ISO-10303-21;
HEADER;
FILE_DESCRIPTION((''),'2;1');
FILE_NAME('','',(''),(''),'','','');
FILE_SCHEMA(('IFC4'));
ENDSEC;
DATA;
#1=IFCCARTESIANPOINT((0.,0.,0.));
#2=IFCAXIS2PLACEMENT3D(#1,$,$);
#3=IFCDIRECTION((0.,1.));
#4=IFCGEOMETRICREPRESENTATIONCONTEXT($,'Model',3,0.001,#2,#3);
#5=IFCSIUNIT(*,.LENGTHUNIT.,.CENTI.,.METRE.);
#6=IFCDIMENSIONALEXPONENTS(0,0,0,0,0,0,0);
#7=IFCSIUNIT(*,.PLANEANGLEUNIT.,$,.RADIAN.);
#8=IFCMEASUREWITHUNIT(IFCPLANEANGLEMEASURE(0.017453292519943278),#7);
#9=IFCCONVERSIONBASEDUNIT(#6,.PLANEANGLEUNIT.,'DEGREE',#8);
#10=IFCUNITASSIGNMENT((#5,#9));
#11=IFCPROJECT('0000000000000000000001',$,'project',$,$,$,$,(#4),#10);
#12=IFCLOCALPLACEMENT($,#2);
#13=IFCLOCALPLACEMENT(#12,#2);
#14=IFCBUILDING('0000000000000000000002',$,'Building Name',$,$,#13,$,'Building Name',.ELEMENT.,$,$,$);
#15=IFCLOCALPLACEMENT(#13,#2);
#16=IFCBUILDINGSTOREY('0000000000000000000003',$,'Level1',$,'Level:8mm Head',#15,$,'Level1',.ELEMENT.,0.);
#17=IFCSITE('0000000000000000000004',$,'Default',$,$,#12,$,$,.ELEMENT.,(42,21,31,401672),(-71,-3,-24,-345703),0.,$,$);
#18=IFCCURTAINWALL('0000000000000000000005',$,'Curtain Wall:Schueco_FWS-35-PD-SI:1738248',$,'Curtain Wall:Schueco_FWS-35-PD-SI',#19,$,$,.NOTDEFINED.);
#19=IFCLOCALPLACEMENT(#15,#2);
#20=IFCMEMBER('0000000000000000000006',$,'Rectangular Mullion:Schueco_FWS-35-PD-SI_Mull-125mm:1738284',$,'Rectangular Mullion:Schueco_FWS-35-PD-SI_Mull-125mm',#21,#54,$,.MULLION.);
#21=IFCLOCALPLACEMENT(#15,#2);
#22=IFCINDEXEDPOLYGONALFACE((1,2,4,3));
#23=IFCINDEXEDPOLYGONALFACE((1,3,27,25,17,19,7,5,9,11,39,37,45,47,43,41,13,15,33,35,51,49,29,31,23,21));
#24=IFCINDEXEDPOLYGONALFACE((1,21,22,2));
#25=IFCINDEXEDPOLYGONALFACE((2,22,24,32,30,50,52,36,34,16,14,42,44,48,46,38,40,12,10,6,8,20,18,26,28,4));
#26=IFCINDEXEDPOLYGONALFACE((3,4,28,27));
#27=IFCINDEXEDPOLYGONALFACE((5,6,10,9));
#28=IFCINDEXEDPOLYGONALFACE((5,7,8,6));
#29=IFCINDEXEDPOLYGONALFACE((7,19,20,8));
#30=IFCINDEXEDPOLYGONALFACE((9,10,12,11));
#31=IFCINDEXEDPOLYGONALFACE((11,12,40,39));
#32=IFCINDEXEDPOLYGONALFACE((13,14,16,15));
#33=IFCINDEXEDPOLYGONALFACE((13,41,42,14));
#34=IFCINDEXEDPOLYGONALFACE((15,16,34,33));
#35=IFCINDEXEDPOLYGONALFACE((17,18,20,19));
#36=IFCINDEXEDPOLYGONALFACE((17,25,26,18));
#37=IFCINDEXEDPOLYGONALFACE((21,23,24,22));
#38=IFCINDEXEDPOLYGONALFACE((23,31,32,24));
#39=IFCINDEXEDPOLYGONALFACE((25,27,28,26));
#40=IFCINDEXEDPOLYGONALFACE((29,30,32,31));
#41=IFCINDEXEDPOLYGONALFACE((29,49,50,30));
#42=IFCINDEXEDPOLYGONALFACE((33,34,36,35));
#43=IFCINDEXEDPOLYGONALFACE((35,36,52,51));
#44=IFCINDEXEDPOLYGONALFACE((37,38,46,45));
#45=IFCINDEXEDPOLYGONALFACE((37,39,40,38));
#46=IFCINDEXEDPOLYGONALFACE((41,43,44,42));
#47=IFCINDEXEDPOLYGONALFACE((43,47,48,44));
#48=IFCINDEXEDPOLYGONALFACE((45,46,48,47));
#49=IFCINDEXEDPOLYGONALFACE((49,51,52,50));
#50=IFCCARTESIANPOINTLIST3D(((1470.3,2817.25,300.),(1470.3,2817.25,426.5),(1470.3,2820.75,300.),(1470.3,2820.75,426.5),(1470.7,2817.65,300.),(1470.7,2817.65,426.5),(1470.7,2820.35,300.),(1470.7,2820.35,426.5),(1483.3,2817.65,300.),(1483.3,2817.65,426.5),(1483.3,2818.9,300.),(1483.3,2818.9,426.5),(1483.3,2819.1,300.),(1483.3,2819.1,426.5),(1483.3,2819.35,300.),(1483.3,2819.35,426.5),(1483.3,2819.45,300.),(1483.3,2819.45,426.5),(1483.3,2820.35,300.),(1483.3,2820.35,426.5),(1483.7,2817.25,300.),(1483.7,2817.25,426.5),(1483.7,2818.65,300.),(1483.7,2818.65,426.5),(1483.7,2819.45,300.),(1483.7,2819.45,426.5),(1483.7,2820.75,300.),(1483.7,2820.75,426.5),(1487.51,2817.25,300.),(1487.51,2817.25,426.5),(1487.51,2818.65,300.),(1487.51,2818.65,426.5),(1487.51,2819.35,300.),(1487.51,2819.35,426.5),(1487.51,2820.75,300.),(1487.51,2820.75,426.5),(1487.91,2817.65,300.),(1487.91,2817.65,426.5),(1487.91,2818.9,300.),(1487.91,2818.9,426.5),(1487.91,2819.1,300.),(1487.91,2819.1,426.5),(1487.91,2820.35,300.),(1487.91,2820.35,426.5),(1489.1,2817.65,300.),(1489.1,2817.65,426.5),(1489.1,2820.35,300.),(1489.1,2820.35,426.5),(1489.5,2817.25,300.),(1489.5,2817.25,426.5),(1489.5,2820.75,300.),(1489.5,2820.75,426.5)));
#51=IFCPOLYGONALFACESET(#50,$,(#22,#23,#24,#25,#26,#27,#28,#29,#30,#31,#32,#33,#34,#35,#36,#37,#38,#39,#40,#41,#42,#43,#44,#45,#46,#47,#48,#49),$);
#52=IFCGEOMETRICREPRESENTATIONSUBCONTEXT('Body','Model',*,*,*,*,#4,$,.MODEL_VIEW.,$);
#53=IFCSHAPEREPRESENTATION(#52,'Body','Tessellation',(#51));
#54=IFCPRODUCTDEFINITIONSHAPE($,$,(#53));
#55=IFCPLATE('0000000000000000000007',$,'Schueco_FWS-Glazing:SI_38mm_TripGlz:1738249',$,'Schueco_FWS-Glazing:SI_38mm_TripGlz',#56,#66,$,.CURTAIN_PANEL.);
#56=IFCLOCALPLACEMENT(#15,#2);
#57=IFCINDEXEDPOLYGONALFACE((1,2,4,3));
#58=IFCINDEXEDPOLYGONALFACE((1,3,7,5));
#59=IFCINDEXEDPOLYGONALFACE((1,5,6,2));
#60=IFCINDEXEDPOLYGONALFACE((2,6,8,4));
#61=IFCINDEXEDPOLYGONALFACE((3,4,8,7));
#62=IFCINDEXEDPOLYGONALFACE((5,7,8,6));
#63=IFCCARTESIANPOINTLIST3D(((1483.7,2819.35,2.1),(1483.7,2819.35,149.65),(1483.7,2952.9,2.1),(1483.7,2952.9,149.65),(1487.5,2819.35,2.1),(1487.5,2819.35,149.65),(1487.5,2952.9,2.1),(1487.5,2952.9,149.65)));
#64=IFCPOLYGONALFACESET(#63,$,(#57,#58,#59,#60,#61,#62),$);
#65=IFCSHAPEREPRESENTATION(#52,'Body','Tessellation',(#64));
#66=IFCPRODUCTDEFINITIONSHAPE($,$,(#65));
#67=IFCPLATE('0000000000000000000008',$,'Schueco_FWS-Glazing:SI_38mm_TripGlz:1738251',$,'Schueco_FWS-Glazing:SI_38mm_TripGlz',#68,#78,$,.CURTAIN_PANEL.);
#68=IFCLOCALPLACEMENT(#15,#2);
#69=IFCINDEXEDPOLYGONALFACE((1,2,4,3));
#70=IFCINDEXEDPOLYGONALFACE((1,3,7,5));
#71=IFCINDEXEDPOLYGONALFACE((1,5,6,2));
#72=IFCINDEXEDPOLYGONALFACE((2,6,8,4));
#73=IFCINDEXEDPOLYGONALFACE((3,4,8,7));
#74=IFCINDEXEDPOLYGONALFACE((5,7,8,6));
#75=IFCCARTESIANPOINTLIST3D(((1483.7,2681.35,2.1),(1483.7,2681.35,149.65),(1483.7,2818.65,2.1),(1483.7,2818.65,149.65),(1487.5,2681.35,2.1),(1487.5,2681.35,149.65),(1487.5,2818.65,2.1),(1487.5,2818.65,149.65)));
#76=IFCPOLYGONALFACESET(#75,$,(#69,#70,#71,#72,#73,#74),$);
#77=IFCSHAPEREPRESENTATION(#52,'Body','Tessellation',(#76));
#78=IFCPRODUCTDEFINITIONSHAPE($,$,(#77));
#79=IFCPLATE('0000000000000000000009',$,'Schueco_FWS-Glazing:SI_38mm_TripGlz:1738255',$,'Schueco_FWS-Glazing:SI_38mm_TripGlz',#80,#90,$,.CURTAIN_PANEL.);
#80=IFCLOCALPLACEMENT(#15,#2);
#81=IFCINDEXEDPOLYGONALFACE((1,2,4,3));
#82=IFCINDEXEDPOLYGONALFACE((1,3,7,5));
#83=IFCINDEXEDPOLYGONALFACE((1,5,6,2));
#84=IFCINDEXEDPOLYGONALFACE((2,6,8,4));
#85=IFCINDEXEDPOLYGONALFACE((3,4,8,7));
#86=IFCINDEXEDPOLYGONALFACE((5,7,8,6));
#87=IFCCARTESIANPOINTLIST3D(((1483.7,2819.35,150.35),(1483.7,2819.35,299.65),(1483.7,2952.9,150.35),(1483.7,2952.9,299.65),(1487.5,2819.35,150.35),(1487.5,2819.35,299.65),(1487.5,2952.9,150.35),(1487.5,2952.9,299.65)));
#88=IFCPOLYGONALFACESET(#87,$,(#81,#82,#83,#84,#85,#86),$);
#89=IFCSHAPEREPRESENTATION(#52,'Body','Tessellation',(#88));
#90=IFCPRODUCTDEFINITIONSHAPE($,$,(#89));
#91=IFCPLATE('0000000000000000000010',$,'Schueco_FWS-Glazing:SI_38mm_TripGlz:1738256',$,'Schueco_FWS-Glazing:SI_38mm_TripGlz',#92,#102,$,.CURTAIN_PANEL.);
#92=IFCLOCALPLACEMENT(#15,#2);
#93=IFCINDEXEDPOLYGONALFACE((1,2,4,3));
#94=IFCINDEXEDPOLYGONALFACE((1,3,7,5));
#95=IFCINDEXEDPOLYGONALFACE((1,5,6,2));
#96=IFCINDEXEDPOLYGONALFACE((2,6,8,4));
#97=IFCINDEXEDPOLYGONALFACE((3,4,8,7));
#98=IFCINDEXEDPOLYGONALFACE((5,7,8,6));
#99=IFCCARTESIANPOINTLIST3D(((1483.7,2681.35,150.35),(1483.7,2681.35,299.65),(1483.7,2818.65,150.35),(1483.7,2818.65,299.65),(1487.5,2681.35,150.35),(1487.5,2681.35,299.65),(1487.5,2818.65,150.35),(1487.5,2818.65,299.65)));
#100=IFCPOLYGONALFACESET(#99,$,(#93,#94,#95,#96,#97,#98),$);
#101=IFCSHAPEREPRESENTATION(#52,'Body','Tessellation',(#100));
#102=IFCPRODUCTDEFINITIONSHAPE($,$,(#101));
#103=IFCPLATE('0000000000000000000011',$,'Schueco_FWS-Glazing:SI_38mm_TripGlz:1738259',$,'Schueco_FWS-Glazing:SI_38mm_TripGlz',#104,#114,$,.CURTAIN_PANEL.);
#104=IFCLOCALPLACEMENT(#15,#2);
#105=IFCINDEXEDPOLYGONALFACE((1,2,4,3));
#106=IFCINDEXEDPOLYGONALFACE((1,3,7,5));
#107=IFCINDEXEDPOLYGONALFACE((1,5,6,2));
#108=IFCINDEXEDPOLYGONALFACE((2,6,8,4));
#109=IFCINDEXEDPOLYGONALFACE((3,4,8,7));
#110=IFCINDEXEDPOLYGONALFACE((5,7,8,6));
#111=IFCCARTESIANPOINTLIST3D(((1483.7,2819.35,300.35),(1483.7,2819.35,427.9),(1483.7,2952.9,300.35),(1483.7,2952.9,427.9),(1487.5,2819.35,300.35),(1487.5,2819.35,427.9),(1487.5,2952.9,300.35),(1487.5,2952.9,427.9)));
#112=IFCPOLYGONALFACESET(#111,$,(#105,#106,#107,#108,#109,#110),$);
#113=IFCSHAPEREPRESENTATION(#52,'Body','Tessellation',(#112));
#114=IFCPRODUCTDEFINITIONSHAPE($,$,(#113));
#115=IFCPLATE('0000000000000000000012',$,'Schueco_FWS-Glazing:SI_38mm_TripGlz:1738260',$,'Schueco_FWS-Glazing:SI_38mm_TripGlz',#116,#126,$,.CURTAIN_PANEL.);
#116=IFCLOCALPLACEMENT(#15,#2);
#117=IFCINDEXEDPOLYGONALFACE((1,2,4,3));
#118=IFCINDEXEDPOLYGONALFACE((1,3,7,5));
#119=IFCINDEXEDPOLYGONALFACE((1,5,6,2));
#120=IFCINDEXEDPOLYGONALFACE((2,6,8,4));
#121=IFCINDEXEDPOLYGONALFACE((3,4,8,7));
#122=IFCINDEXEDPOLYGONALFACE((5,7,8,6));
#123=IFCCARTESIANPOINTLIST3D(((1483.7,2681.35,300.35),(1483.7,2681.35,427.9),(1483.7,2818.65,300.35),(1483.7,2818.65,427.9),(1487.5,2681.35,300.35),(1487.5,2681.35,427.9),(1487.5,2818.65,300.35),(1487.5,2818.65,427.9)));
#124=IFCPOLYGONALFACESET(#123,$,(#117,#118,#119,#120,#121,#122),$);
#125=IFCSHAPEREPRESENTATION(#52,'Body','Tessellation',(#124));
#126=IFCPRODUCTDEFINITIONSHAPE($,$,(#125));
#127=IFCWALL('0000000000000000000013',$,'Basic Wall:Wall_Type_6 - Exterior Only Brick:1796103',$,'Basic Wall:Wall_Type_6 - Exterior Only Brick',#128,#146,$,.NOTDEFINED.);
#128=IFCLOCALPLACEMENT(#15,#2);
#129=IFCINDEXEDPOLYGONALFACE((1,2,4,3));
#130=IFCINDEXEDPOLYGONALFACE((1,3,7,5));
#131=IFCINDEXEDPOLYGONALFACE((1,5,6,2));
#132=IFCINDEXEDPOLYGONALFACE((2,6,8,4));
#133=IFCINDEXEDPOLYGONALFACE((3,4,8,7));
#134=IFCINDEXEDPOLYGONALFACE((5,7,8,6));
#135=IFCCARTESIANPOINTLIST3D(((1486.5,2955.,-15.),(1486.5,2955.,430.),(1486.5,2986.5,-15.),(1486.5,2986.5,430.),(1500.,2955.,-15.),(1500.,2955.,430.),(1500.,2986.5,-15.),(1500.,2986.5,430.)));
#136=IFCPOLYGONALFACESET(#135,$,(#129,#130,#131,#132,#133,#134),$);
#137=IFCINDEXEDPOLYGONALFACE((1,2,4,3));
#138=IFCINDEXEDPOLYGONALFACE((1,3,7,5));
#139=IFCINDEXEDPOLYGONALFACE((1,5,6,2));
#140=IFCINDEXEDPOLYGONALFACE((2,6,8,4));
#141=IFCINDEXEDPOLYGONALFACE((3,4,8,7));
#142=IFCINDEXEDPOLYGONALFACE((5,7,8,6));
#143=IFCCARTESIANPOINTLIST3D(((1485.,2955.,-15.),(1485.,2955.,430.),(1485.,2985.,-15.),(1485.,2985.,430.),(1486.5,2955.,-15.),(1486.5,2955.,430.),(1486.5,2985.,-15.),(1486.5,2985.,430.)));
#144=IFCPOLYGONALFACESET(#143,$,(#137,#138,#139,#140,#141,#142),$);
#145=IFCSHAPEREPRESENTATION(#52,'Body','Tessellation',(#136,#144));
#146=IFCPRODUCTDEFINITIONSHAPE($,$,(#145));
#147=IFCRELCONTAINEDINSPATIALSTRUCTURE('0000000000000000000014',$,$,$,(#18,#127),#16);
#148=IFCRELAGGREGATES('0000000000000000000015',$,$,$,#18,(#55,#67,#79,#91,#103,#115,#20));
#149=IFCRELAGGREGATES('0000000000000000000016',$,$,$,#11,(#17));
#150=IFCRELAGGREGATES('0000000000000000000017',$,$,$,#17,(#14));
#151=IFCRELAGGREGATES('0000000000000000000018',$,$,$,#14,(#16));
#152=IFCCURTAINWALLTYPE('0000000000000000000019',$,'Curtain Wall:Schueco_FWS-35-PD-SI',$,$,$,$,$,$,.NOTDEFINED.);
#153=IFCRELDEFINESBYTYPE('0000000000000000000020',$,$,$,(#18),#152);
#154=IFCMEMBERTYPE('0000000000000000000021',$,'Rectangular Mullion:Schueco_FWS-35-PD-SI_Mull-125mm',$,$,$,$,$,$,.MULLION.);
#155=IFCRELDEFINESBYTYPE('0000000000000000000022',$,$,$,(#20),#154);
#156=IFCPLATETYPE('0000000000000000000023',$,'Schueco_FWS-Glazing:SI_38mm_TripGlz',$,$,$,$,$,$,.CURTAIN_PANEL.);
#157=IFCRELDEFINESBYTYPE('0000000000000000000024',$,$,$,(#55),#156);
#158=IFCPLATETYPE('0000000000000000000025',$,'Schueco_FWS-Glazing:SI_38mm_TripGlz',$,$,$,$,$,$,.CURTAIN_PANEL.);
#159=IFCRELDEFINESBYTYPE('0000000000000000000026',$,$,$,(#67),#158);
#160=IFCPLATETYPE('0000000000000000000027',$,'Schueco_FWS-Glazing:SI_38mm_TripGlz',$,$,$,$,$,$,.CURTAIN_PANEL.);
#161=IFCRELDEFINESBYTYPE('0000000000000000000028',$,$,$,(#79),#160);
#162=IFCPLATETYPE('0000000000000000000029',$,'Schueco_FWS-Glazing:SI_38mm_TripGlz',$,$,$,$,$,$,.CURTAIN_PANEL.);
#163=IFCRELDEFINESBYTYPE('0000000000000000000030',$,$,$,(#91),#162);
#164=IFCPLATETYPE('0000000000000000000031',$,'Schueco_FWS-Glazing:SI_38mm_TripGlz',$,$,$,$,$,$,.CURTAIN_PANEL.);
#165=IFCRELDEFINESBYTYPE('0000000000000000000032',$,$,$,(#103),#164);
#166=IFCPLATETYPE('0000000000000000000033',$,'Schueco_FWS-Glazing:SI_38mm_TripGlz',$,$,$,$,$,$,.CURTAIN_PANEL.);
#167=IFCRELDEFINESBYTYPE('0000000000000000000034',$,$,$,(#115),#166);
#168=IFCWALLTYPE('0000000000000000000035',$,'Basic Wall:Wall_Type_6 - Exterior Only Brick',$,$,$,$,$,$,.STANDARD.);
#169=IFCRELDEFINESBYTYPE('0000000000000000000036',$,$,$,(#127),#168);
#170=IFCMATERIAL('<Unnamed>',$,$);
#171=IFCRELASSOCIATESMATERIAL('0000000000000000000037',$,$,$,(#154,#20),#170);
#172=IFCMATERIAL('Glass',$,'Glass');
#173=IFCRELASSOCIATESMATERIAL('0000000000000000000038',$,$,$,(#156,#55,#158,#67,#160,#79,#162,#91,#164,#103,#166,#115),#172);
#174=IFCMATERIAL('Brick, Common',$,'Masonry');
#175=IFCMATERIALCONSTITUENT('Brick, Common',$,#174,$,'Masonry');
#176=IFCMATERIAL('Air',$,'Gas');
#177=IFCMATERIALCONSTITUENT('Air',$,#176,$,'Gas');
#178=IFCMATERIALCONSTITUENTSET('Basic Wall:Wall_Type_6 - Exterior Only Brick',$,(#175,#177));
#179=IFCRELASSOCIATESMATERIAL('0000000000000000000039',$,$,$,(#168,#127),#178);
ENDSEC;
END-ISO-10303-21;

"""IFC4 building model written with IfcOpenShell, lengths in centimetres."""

from ifc_helpers import new_model, entity, si_unit, converted_unit, direction, frame, origin, place, context, subcontext, project, spatial, indexed_curve, outline, extrude, source, transform, mapped, material, constituent, constituent_set, type_object, type_shapes, element, aggregate, save


model = new_model("IFC4")

# Units and contexts
model_context = context("Model", 3, precision=0.001, world=origin(), true_north=direction((0.0, 1.0)))
body_context = subcontext(model_context, "Body", "Model", "MODEL_VIEW")
ifc_project = project(units=[si_unit("LENGTHUNIT", "METRE", prefix="CENTI"), converted_unit("PLANEANGLEUNIT", "DEGREE", entity("IfcPlaneAngleMeasure", 0.017453292519943278), si_unit("PLANEANGLEUNIT", "RADIAN"), dimensions=[0, 0, 0, 0, 0, 0, 0])], contexts=[model_context])

# Site, building, storey
site_placement = place(None, origin())
site = spatial("IfcSite", under=ifc_project, at=site_placement, Name="Default", CompositionType="ELEMENT", RefLatitude=(42, 21, 31, 401672), RefLongitude=(-71, -3, -24, -345703), RefElevation=0.0)
building_placement = place(site_placement, origin())
building = spatial("IfcBuilding", under=site, at=building_placement, Name="Building Name", LongName="Building Name", CompositionType="ELEMENT")
storey_placement = place(building_placement, origin())
storey = spatial("IfcBuildingStorey", under=building, at=storey_placement, Name="Level1", ObjectType="Level:8mm Head", LongName="Level1", CompositionType="ELEMENT", Elevation=0.0)

# Curtain wall, member, plates
curtain_wall_type = type_object("IfcCurtainWallType", Name="Curtain Wall:Schueco_FWS-35-PD-SI", PredefinedType="NOTDEFINED")
curtain_wall_placement = place(storey_placement, origin())
curtain_wall = element("IfcCurtainWall", 1, at=curtain_wall_placement, inside=storey, type_object=curtain_wall_type, Name="Curtain Wall:Schueco_FWS-35-PD-SI:1738248", ObjectType="Curtain Wall:Schueco_FWS-35-PD-SI", PredefinedType="NOTDEFINED")
ifc_material_1 = material(Name="<Unnamed>")
member_type_1 = type_object("IfcMemberType", Name="Rectangular Mullion:Schueco_FWS-35-PD-SI_Mull-125mm", PredefinedType="MULLION", material=ifc_material_1)
shared_shape_1 = source(origin(), body_context, "Body", "SweptSolid", [
    extrude(outline(indexed_curve([(-1.78, -13.37), (1.72, -13.37), (1.72, 0.03), (0.42, 0.03), (0.42, -0.37), (1.32, -0.37), (1.32, -12.97), (-1.38, -12.97), (-1.38, -0.37), (-0.13, -0.37), (-0.13, 4.24), (-1.38, 4.24), (-1.38, 5.43), (1.32, 5.43), (1.32, 4.24), (0.07, 4.24), (0.07, -0.37), (0.32, -0.37), (0.32, 3.84), (1.72, 3.84), (1.72, 5.83), (-1.78, 5.83), (-1.78, 3.84), (-0.38, 3.84), (-0.38, 0.03), (-1.78, 0.03), (-1.78, -13.37)], self_intersect=False)), frame((-0.03, 3.83, -126.5), z_axis=(0.0, 0.0, 1.0), x_axis=(-1.0, 0.0, 0.0)), (0.0, 0.0, 1.0), 126.5),
])
type_shapes(member_type_1, [shared_shape_1])
member_1_placement = place(curtain_wall_placement, frame((1487.5, 2819.0, 300.0), z_axis=(0.0, 0.0, -1.0), x_axis=(0.0, -1.0, 0.0)))
member_1 = element("IfcMember", 2, at=member_1_placement, type_object=member_type_1, material=ifc_material_1, Name="Rectangular Mullion:Schueco_FWS-35-PD-SI_Mull-125mm:1738284", ObjectType="Rectangular Mullion:Schueco_FWS-35-PD-SI_Mull-125mm", PredefinedType="MULLION", context=body_context, shape_type="MappedRepresentation", body=[
    mapped(shared_shape_1, transform((0.0, 0.0, 0.0), scale=1.0)),
])
ifc_material_2 = material(Name="Glass", Category="Glass")
plate_type_1 = type_object("IfcPlateType", Name="Schueco_FWS-Glazing:SI_38mm_TripGlz", PredefinedType="CURTAIN_PANEL", material=ifc_material_2)
shared_shape_2 = source(origin(), body_context, "Body", "SweptSolid", [
    extrude(outline(indexed_curve([(-1.9, -66.78), (1.9, -66.78), (1.9, 66.78), (-1.9, 66.78), (-1.9, -66.78)], self_intersect=False)), frame((0.0, -1.9, 0.0), z_axis=(0.0, 0.0, 1.0), x_axis=(0.0, 1.0, 0.0)), (0.0, 0.0, 1.0), 147.55),
])
type_shapes(plate_type_1, [shared_shape_2])
plate_1_placement = place(curtain_wall_placement, frame((1487.5, 2886.12, 2.1), z_axis=(0.0, 0.0, 1.0), x_axis=(0.0, -1.0, 0.0)))
plate_1 = element("IfcPlate", 3, at=plate_1_placement, type_object=plate_type_1, material=ifc_material_2, Name="Schueco_FWS-Glazing:SI_38mm_TripGlz:1738249", ObjectType="Schueco_FWS-Glazing:SI_38mm_TripGlz", PredefinedType="CURTAIN_PANEL", context=body_context, shape_type="MappedRepresentation", body=[
    mapped(shared_shape_2, transform((0.0, 0.0, 0.0), scale=1.0)),
])
plate_type_2 = type_object("IfcPlateType", Name="Schueco_FWS-Glazing:SI_38mm_TripGlz", PredefinedType="CURTAIN_PANEL", material=ifc_material_2)
shared_shape_3 = source(origin(), body_context, "Body", "SweptSolid", [
    extrude(outline(indexed_curve([(-1.9, -68.65), (1.9, -68.65), (1.9, 68.65), (-1.9, 68.65), (-1.9, -68.65)], self_intersect=False)), frame((0.0, -1.9, 0.0), z_axis=(0.0, 0.0, 1.0), x_axis=(0.0, 1.0, 0.0)), (0.0, 0.0, 1.0), 147.55),
])
type_shapes(plate_type_2, [shared_shape_3])
plate_2_placement = place(curtain_wall_placement, frame((1487.5, 2750.0, 2.1), z_axis=(0.0, 0.0, 1.0), x_axis=(0.0, -1.0, 0.0)))
plate_2 = element("IfcPlate", 4, at=plate_2_placement, type_object=plate_type_2, material=ifc_material_2, Name="Schueco_FWS-Glazing:SI_38mm_TripGlz:1738251", ObjectType="Schueco_FWS-Glazing:SI_38mm_TripGlz", PredefinedType="CURTAIN_PANEL", context=body_context, shape_type="MappedRepresentation", body=[
    mapped(shared_shape_3, transform((0.0, 0.0, 0.0), scale=1.0)),
])
plate_type_3 = type_object("IfcPlateType", Name="Schueco_FWS-Glazing:SI_38mm_TripGlz", PredefinedType="CURTAIN_PANEL", material=ifc_material_2)
shared_shape_4 = source(origin(), body_context, "Body", "SweptSolid", [
    extrude(outline(indexed_curve([(-1.9, -66.78), (1.9, -66.78), (1.9, 66.78), (-1.9, 66.78), (-1.9, -66.78)], self_intersect=False)), frame((0.0, -1.9, 0.0), z_axis=(0.0, 0.0, 1.0), x_axis=(0.0, 1.0, 0.0)), (0.0, 0.0, 1.0), 149.3),
])
type_shapes(plate_type_3, [shared_shape_4])
plate_3_placement = place(curtain_wall_placement, frame((1487.5, 2886.12, 150.35), z_axis=(0.0, 0.0, 1.0), x_axis=(0.0, -1.0, 0.0)))
plate_3 = element("IfcPlate", 5, at=plate_3_placement, type_object=plate_type_3, material=ifc_material_2, Name="Schueco_FWS-Glazing:SI_38mm_TripGlz:1738255", ObjectType="Schueco_FWS-Glazing:SI_38mm_TripGlz", PredefinedType="CURTAIN_PANEL", context=body_context, shape_type="MappedRepresentation", body=[
    mapped(shared_shape_4, transform((0.0, 0.0, 0.0), scale=1.0)),
])
plate_type_4 = type_object("IfcPlateType", Name="Schueco_FWS-Glazing:SI_38mm_TripGlz", PredefinedType="CURTAIN_PANEL", material=ifc_material_2)
shared_shape_5 = source(origin(), body_context, "Body", "SweptSolid", [
    extrude(outline(indexed_curve([(-1.9, -68.65), (1.9, -68.65), (1.9, 68.65), (-1.9, 68.65), (-1.9, -68.65)], self_intersect=False)), frame((0.0, -1.9, 0.0), z_axis=(0.0, 0.0, 1.0), x_axis=(0.0, 1.0, 0.0)), (0.0, 0.0, 1.0), 149.3),
])
type_shapes(plate_type_4, [shared_shape_5])
plate_4_placement = place(curtain_wall_placement, frame((1487.5, 2750.0, 150.35), z_axis=(0.0, 0.0, 1.0), x_axis=(0.0, -1.0, 0.0)))
plate_4 = element("IfcPlate", 6, at=plate_4_placement, type_object=plate_type_4, material=ifc_material_2, Name="Schueco_FWS-Glazing:SI_38mm_TripGlz:1738256", ObjectType="Schueco_FWS-Glazing:SI_38mm_TripGlz", PredefinedType="CURTAIN_PANEL", context=body_context, shape_type="MappedRepresentation", body=[
    mapped(shared_shape_5, transform((0.0, 0.0, 0.0), scale=1.0)),
])
plate_type_5 = type_object("IfcPlateType", Name="Schueco_FWS-Glazing:SI_38mm_TripGlz", PredefinedType="CURTAIN_PANEL", material=ifc_material_2)
shared_shape_6 = source(origin(), body_context, "Body", "SweptSolid", [
    extrude(outline(indexed_curve([(-1.9, -66.77), (1.9, -66.77), (1.9, 66.77), (-1.9, 66.77), (-1.9, -66.77)], self_intersect=False)), frame((0.0, -1.9, 0.0), z_axis=(0.0, 0.0, 1.0), x_axis=(0.0, 1.0, 0.0)), (0.0, 0.0, 1.0), 127.55),
])
type_shapes(plate_type_5, [shared_shape_6])
plate_5_placement = place(curtain_wall_placement, frame((1487.5, 2886.12, 300.35), z_axis=(0.0, 0.0, 1.0), x_axis=(0.0, -1.0, 0.0)))
plate_5 = element("IfcPlate", 7, at=plate_5_placement, type_object=plate_type_5, material=ifc_material_2, Name="Schueco_FWS-Glazing:SI_38mm_TripGlz:1738259", ObjectType="Schueco_FWS-Glazing:SI_38mm_TripGlz", PredefinedType="CURTAIN_PANEL", context=body_context, shape_type="MappedRepresentation", body=[
    mapped(shared_shape_6, transform((0.0, 0.0, 0.0), scale=1.0)),
])
plate_type_6 = type_object("IfcPlateType", Name="Schueco_FWS-Glazing:SI_38mm_TripGlz", PredefinedType="CURTAIN_PANEL", material=ifc_material_2)
shared_shape_7 = source(origin(), body_context, "Body", "SweptSolid", [
    extrude(outline(indexed_curve([(-1.9, -68.65), (1.9, -68.65), (1.9, 68.65), (-1.9, 68.65), (-1.9, -68.65)], self_intersect=False)), frame((0.0, -1.9, 0.0), z_axis=(0.0, 0.0, 1.0), x_axis=(0.0, 1.0, 0.0)), (0.0, 0.0, 1.0), 127.55),
])
type_shapes(plate_type_6, [shared_shape_7])
plate_6_placement = place(curtain_wall_placement, frame((1487.5, 2750.0, 300.35), z_axis=(0.0, 0.0, 1.0), x_axis=(0.0, -1.0, 0.0)))
plate_6 = element("IfcPlate", 8, at=plate_6_placement, type_object=plate_type_6, material=ifc_material_2, Name="Schueco_FWS-Glazing:SI_38mm_TripGlz:1738260", ObjectType="Schueco_FWS-Glazing:SI_38mm_TripGlz", PredefinedType="CURTAIN_PANEL", context=body_context, shape_type="MappedRepresentation", body=[
    mapped(shared_shape_7, transform((0.0, 0.0, 0.0), scale=1.0)),
])
aggregate(curtain_wall, [plate_1, plate_2, plate_3, plate_4, plate_5, plate_6, member_1])

# Shared definitions
ifc_material_3 = material(Name="Brick, Common", Category="Masonry")
ifc_material_4 = material(Name="Air", Category="Gas")

# Wall
ifc_constituent_1 = constituent(ifc_material_3, Name="Brick, Common", Category="Masonry")
ifc_constituent_2 = constituent(ifc_material_4, Name="Air", Category="Gas")
ifc_constituent_set_1 = constituent_set(constituents=[ifc_constituent_1, ifc_constituent_2], Name="Basic Wall:Wall_Type_6 - Exterior Only Brick")
wall_type_1 = type_object("IfcWallType", Name="Basic Wall:Wall_Type_6 - Exterior Only Brick", PredefinedType="STANDARD", material=ifc_constituent_set_1)
wall_1_placement = place(storey_placement, frame((1492.5, 2985.0, -15.0), z_axis=(0.0, 0.0, 1.0), x_axis=(0.0, -1.0, 0.0)))
element("IfcWall", 9, at=wall_1_placement, inside=storey, type_object=wall_type_1, material=ifc_constituent_set_1, Name="Basic Wall:Wall_Type_6 - Exterior Only Brick:1796103", ObjectType="Basic Wall:Wall_Type_6 - Exterior Only Brick", PredefinedType="NOTDEFINED", context=body_context, shape_type="SweptSolid", body=[
    extrude(outline(indexed_curve([(-6.75, -15.75), (6.75, -15.75), (6.75, 15.75), (-6.75, 15.75), (-6.75, -15.75)], self_intersect=False)), frame((14.25, 0.75, 0.0), z_axis=(0.0, 0.0, 1.0), x_axis=(0.0, -1.0, 0.0)), (0.0, 0.0, 1.0), 445.0),
    extrude(outline(indexed_curve([(-0.75, -15.0), (0.75, -15.0), (0.75, 15.0), (-0.75, 15.0), (-0.75, -15.0)], self_intersect=False)), frame((15.0, -6.75, 0.0), z_axis=(0.0, 0.0, 1.0), x_axis=(0.0, 1.0, 0.0)), (0.0, 0.0, 1.0), 445.0),
])

save(model, "model.ifc")
